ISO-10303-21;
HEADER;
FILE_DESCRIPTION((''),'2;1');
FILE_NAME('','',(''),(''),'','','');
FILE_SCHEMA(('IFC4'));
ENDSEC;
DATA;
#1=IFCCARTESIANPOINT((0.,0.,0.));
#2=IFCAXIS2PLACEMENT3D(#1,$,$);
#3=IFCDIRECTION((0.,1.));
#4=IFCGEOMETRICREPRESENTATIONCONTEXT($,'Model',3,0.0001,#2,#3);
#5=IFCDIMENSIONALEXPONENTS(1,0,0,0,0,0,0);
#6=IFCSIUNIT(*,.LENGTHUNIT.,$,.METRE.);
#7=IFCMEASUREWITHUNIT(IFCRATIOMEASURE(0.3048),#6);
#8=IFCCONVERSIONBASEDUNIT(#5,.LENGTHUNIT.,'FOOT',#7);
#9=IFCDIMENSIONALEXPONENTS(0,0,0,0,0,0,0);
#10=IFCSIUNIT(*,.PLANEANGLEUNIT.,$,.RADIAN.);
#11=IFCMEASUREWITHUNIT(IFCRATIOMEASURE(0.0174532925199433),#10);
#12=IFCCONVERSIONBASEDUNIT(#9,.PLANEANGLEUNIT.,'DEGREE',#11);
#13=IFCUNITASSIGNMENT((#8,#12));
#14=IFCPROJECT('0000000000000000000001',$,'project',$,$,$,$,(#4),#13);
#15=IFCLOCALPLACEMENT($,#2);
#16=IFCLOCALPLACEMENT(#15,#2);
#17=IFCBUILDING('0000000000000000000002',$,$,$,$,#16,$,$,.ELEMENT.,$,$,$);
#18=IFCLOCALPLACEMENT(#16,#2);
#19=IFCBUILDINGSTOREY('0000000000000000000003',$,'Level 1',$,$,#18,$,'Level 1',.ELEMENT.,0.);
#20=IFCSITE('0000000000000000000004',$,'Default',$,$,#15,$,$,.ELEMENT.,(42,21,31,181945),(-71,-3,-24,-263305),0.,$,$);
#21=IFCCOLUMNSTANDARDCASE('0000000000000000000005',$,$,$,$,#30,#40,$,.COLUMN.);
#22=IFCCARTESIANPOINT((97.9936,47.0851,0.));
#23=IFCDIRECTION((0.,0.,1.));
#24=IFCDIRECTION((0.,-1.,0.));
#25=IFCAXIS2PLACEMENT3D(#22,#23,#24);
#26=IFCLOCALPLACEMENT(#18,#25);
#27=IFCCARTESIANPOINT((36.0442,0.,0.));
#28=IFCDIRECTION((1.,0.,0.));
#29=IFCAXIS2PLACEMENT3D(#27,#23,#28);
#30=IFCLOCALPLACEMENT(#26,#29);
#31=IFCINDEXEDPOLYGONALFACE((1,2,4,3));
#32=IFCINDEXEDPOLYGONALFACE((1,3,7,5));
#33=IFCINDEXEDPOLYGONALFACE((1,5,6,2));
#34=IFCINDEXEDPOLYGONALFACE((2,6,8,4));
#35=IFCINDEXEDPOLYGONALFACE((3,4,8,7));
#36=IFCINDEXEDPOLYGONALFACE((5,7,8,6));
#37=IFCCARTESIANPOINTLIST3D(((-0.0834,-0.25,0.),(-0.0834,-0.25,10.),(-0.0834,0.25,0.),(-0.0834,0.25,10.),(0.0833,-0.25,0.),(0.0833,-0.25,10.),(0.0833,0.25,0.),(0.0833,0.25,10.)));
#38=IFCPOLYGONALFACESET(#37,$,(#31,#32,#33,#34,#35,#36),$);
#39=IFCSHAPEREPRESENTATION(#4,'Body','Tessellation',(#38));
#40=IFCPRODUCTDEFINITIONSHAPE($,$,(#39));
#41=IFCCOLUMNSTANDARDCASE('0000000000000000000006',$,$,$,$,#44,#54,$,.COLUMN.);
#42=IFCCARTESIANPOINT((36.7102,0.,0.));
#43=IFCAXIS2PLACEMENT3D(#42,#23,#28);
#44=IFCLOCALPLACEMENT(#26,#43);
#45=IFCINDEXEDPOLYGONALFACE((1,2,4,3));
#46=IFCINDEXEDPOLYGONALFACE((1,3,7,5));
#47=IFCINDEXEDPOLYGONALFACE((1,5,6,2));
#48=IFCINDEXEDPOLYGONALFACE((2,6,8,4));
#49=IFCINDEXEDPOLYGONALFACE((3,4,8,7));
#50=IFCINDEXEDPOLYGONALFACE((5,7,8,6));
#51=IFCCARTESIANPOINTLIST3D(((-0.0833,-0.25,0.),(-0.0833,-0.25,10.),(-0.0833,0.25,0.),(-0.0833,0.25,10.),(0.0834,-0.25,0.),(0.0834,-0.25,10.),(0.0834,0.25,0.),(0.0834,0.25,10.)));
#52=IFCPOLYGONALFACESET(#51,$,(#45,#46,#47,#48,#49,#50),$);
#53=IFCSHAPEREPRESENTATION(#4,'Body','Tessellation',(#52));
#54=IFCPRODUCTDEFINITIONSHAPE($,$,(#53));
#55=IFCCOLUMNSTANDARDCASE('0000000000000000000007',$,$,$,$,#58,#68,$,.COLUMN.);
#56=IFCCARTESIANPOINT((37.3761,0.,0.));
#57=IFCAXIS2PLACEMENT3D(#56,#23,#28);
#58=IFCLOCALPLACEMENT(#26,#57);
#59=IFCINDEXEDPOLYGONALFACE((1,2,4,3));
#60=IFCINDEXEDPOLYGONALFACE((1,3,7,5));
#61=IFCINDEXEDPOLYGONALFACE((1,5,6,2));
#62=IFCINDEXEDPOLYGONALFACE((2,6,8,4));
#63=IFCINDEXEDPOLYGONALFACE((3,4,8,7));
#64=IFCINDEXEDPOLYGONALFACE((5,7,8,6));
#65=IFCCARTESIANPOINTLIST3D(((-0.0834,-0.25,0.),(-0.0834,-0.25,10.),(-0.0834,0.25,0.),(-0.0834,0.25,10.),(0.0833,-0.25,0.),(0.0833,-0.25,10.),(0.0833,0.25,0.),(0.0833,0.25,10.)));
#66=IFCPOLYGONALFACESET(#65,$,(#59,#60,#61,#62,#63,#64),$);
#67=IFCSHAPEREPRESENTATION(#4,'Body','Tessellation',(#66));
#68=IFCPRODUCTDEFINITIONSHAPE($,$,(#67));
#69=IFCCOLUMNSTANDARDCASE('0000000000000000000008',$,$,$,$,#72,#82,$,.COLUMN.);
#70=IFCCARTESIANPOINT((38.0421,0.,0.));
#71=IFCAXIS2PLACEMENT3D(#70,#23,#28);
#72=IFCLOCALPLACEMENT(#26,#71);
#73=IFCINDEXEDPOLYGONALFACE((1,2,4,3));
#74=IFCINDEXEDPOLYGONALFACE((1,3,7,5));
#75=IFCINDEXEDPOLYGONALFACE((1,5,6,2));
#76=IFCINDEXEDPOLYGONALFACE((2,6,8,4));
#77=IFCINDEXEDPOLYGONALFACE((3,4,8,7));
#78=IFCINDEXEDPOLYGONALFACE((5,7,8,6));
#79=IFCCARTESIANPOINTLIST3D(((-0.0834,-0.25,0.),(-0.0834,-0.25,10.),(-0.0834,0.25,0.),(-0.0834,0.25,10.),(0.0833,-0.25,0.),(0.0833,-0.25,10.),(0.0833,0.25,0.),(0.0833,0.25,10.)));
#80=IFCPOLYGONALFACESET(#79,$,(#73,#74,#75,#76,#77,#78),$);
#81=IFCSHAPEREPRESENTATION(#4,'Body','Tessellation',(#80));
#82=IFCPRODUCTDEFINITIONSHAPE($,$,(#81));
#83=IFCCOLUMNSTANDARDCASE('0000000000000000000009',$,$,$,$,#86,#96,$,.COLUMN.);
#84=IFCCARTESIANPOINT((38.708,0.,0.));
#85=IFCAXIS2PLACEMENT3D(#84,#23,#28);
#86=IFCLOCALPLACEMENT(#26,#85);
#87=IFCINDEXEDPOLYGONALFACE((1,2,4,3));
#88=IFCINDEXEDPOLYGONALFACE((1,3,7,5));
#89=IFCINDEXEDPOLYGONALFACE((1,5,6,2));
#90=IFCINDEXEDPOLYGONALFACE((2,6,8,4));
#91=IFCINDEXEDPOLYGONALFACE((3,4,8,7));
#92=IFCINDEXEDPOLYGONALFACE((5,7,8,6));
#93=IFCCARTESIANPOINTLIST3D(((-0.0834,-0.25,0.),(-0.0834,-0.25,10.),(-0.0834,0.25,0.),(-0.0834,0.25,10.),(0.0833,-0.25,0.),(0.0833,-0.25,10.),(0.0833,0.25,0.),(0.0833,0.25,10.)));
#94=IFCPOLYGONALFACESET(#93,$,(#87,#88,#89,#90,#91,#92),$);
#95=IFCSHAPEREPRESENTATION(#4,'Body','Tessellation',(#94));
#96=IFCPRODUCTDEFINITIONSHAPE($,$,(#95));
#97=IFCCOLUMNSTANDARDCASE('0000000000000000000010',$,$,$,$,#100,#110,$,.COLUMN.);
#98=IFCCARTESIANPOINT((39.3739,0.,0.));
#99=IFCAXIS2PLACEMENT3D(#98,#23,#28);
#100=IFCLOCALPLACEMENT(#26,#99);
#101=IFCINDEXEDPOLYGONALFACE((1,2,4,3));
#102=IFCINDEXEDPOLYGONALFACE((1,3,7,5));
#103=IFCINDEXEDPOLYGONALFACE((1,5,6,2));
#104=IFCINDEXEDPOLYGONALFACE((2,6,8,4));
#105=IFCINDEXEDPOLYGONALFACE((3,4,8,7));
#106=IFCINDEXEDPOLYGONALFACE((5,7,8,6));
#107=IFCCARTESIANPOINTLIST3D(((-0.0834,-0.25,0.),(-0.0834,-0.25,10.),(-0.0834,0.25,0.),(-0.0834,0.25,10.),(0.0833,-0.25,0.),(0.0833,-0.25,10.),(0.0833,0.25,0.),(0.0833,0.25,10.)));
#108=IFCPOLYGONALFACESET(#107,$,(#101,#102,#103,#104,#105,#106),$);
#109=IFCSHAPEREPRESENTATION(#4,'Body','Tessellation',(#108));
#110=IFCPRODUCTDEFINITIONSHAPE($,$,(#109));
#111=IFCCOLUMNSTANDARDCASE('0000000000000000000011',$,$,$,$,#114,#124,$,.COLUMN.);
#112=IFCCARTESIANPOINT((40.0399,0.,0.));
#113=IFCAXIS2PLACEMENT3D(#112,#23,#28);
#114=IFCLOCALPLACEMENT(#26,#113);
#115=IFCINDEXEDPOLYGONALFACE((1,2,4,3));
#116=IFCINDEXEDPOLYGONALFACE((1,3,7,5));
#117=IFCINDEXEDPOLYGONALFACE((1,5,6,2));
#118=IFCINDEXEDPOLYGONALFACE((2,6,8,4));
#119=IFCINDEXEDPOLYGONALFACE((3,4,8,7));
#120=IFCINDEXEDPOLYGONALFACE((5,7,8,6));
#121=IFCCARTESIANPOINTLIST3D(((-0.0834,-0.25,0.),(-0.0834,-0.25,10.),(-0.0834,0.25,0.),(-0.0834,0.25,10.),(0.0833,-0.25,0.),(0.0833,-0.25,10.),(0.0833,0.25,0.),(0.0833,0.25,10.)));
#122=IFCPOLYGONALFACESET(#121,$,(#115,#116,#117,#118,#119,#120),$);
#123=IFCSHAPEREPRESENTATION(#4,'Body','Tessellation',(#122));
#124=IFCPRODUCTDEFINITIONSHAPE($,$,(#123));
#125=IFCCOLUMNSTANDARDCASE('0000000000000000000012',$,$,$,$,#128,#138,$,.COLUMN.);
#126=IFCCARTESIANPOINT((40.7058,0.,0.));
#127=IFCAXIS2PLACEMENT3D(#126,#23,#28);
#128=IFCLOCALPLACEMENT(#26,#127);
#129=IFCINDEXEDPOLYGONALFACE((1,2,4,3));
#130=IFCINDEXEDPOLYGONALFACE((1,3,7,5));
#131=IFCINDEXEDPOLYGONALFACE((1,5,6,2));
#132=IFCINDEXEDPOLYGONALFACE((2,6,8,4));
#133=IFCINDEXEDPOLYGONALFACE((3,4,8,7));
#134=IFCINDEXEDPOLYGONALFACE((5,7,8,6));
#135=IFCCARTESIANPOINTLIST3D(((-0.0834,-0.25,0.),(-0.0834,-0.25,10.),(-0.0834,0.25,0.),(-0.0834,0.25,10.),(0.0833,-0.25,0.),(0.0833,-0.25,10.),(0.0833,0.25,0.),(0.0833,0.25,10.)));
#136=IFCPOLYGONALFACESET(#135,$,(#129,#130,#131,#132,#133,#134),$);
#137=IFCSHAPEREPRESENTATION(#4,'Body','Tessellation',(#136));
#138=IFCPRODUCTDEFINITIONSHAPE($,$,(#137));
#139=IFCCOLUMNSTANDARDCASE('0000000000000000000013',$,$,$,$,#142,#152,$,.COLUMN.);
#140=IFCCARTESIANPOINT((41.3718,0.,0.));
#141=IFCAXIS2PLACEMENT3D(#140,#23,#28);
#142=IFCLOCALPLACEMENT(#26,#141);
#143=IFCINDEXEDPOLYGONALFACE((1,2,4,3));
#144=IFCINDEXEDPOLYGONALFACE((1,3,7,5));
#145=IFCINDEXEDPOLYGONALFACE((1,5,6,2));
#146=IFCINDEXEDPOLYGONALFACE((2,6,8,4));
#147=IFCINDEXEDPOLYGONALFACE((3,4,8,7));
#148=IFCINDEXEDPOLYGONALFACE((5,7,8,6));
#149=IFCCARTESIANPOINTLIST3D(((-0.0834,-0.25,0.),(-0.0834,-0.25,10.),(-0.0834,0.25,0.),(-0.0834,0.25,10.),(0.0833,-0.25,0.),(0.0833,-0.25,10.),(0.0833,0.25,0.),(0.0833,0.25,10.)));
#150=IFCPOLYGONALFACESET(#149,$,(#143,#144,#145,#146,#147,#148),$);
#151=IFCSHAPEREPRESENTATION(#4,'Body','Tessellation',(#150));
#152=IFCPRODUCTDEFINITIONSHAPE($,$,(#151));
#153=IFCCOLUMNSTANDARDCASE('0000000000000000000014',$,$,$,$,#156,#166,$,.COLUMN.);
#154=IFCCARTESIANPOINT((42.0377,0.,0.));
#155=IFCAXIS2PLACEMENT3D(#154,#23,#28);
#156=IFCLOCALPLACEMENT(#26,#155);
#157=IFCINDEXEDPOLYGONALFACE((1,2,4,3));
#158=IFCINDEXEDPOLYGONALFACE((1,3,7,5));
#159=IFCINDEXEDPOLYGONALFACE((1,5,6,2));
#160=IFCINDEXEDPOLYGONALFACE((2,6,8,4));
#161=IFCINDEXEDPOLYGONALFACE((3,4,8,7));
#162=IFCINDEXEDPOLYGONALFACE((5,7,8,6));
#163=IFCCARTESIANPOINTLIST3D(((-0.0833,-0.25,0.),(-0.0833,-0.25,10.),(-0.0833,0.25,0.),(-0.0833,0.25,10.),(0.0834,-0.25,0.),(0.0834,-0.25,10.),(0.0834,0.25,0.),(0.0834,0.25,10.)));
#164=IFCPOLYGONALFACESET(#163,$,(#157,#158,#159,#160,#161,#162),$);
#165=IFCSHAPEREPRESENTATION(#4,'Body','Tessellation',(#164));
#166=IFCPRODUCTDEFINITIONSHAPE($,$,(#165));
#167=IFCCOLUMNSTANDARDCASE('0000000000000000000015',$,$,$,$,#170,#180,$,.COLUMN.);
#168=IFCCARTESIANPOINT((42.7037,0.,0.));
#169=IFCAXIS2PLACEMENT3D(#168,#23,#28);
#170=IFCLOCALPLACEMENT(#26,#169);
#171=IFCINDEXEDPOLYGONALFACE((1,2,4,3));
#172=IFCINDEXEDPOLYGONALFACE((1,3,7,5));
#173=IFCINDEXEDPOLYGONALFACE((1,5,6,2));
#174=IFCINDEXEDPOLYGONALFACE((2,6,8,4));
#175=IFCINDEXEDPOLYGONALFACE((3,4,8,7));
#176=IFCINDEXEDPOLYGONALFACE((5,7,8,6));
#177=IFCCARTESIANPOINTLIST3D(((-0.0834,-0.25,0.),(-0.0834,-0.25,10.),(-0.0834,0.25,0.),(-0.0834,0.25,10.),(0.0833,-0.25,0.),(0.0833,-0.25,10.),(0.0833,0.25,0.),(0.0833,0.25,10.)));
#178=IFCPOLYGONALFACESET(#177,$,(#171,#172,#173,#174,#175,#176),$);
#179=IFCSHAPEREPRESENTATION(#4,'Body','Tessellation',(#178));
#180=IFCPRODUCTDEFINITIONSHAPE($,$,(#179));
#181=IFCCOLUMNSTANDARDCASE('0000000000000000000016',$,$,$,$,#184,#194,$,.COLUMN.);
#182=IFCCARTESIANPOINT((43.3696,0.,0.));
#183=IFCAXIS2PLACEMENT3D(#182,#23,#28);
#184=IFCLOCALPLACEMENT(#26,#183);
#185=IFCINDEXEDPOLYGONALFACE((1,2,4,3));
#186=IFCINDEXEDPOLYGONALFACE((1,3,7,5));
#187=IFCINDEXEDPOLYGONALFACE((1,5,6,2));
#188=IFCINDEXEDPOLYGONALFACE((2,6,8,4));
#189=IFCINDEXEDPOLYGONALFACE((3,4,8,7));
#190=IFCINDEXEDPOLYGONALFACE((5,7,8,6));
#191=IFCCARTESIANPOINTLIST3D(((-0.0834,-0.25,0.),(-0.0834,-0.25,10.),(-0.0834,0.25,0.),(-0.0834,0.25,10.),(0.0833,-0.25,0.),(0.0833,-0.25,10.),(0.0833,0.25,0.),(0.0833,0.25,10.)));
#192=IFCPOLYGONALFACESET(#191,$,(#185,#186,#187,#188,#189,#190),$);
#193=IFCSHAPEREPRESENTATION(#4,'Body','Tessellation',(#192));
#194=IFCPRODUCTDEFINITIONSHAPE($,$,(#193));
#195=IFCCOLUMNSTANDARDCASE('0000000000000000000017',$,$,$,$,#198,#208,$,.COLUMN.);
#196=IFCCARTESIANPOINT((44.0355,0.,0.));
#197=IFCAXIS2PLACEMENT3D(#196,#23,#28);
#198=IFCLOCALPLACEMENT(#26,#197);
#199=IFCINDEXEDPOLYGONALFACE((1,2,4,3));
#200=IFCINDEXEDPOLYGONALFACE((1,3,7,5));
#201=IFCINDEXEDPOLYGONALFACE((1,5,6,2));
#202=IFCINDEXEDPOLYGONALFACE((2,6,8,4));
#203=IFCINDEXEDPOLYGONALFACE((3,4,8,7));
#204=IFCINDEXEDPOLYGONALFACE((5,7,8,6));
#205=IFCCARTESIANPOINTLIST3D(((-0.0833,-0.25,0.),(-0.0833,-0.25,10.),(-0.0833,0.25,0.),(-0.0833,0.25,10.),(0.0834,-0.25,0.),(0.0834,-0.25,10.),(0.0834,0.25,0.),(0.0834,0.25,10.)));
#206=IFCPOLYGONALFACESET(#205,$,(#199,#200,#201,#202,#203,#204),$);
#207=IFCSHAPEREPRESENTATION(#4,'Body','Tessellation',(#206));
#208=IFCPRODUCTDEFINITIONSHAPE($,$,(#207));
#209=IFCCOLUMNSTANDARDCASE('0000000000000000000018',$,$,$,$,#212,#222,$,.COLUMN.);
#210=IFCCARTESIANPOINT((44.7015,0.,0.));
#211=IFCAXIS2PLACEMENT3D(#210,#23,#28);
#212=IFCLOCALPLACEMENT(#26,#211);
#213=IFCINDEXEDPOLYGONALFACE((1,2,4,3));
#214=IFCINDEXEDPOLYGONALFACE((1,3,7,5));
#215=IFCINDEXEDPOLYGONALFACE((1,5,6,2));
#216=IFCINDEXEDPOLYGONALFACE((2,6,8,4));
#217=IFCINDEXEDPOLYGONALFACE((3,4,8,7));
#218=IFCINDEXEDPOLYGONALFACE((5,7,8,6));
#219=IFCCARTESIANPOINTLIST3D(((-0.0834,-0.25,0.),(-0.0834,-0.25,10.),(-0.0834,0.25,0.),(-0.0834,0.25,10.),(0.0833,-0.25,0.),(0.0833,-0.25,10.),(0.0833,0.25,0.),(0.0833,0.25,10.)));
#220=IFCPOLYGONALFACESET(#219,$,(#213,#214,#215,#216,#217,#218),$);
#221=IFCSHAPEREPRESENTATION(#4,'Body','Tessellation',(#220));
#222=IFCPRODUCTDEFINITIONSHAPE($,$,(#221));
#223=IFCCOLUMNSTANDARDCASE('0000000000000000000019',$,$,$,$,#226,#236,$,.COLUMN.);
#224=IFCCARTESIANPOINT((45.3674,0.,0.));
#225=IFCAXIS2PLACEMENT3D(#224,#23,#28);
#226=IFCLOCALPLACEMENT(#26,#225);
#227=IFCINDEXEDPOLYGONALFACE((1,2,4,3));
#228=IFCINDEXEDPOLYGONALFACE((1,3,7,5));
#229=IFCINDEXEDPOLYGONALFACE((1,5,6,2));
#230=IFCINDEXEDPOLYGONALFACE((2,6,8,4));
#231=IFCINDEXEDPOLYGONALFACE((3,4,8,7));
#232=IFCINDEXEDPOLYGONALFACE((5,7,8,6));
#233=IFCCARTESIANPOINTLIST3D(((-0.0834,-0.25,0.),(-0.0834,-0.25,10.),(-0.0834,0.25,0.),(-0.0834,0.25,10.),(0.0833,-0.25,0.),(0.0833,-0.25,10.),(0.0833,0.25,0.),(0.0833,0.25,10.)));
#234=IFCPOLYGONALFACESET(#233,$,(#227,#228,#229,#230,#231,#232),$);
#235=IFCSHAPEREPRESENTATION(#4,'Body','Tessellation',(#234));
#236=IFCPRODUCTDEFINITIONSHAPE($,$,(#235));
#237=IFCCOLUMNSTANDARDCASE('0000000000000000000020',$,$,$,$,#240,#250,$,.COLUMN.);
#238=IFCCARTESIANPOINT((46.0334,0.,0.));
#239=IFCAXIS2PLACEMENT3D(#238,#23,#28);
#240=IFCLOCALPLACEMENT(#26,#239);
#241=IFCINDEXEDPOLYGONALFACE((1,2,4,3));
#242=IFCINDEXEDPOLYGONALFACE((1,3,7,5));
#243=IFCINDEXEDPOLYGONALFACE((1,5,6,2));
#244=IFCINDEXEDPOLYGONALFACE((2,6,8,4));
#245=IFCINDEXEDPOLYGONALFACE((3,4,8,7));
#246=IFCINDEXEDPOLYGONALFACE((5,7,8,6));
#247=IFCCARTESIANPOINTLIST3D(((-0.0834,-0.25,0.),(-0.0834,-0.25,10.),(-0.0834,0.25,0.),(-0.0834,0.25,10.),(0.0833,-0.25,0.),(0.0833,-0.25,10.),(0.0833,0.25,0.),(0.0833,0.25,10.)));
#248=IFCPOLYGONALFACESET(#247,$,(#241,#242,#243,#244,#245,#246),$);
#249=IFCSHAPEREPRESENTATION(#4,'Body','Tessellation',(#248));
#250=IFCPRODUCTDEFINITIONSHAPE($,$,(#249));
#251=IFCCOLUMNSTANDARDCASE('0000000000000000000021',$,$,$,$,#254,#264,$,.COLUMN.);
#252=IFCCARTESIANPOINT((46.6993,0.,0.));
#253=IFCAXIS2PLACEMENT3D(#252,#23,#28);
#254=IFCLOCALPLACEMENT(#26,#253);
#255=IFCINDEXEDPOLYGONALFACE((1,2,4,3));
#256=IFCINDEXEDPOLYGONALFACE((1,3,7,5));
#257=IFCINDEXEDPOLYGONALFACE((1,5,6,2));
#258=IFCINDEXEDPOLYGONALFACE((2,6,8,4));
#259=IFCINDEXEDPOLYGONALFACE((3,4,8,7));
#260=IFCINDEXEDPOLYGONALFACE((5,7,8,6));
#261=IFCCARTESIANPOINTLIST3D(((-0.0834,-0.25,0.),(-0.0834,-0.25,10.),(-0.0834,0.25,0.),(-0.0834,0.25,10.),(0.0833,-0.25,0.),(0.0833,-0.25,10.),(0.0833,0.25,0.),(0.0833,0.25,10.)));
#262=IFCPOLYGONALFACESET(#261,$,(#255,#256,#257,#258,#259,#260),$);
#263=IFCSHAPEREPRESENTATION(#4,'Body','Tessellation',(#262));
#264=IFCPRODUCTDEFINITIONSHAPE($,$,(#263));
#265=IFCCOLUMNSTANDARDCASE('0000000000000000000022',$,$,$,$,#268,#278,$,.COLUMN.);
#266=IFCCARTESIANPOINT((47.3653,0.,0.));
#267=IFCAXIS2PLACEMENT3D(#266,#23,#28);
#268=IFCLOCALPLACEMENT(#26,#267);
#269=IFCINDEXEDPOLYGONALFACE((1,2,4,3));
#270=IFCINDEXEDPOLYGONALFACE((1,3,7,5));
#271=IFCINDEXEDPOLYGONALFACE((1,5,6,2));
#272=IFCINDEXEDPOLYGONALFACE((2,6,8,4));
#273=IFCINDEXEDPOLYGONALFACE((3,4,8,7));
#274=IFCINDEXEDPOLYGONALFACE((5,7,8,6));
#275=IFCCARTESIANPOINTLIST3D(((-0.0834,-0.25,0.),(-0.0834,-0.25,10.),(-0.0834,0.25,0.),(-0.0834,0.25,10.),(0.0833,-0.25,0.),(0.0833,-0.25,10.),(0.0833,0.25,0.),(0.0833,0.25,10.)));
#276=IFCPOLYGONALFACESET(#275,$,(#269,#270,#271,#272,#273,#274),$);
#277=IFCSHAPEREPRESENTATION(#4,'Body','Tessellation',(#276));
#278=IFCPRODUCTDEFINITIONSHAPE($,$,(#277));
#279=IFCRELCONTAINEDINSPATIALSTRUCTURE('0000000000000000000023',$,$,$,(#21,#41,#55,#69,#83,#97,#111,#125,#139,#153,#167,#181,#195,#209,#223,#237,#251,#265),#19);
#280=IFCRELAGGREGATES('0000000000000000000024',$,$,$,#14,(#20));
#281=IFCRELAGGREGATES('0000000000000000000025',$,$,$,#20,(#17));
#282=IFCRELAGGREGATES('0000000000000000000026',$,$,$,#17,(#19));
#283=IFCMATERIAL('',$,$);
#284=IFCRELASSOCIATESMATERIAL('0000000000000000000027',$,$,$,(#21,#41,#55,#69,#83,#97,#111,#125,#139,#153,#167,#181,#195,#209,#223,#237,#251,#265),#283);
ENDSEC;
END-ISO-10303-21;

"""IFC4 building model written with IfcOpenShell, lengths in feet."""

from ifc_helpers import new_model, entity, si_unit, converted_unit, direction, frame, origin, place, context, project, spatial, rectangle, extrude, material, element, save


model = new_model("IFC4")

# Units and contexts
model_context = context("Model", 3, precision=0.0001, world=origin(), true_north=direction((0.0, 1.0)))
ifc_project = project(units=[converted_unit("LENGTHUNIT", "FOOT", entity("IfcRatioMeasure", 0.3048), si_unit("LENGTHUNIT", "METRE"), dimensions=[1, 0, 0, 0, 0, 0, 0]), converted_unit("PLANEANGLEUNIT", "DEGREE", entity("IfcRatioMeasure", 0.0174532925199433), si_unit("PLANEANGLEUNIT", "RADIAN"), dimensions=[0, 0, 0, 0, 0, 0, 0])], contexts=[model_context])

# Site, building, storey
site_placement = place(None, origin())
site = spatial("IfcSite", under=ifc_project, at=site_placement, Name="Default", CompositionType="ELEMENT", RefLatitude=(42, 21, 31, 181945), RefLongitude=(-71, -3, -24, -263305), RefElevation=0.0)
building_placement = place(site_placement, origin())
building = spatial("IfcBuilding", under=site, at=building_placement, CompositionType="ELEMENT")
storey_placement = place(building_placement, origin())
storey = spatial("IfcBuildingStorey", under=building, at=storey_placement, Name="Level 1", LongName="Level 1", CompositionType="ELEMENT", Elevation=0.0)

# Columns
ifc_material_1 = material(Name="")
placement = place(storey_placement, frame((97.9936, 47.0851, 0.0), z_axis=(0.0, 0.0, 1.0), x_axis=(0.0, -1.0, 0.0)))
for number, where, z_axis, x_axis in (
    (1, (36.0442, 0.0, 0.0), (0.0, 0.0, 1.0), (1.0, 0.0, 0.0)),
    (2, (36.7102, 0.0, 0.0), (0.0, 0.0, 1.0), (1.0, 0.0, 0.0)),
    (3, (37.3761, 0.0, 0.0), (0.0, 0.0, 1.0), (1.0, 0.0, 0.0)),
    (4, (38.0421, 0.0, 0.0), (0.0, 0.0, 1.0), (1.0, 0.0, 0.0)),
    (5, (38.708, 0.0, 0.0), (0.0, 0.0, 1.0), (1.0, 0.0, 0.0)),
    (6, (39.3739, 0.0, 0.0), (0.0, 0.0, 1.0), (1.0, 0.0, 0.0)),
    (7, (40.0399, 0.0, 0.0), (0.0, 0.0, 1.0), (1.0, 0.0, 0.0)),
    (8, (40.7058, 0.0, 0.0), (0.0, 0.0, 1.0), (1.0, 0.0, 0.0)),
    (9, (41.3718, 0.0, 0.0), (0.0, 0.0, 1.0), (1.0, 0.0, 0.0)),
    (10, (42.0377, 0.0, 0.0), (0.0, 0.0, 1.0), (1.0, 0.0, 0.0)),
    (11, (42.7037, 0.0, 0.0), (0.0, 0.0, 1.0), (1.0, 0.0, 0.0)),
    (12, (43.3696, 0.0, 0.0), (0.0, 0.0, 1.0), (1.0, 0.0, 0.0)),
    (13, (44.0355, 0.0, 0.0), (0.0, 0.0, 1.0), (1.0, 0.0, 0.0)),
    (14, (44.7015, 0.0, 0.0), (0.0, 0.0, 1.0), (1.0, 0.0, 0.0)),
    (15, (45.3674, 0.0, 0.0), (0.0, 0.0, 1.0), (1.0, 0.0, 0.0)),
    (16, (46.0334, 0.0, 0.0), (0.0, 0.0, 1.0), (1.0, 0.0, 0.0)),
    (17, (46.6993, 0.0, 0.0), (0.0, 0.0, 1.0), (1.0, 0.0, 0.0)),
    (18, (47.3653, 0.0, 0.0), (0.0, 0.0, 1.0), (1.0, 0.0, 0.0)),
):
    element("IfcColumnStandardCase", number, at=place(placement, frame(where, z_axis=z_axis, x_axis=x_axis)), inside=storey, material=ifc_material_1, PredefinedType="COLUMN", context=model_context, shape_type="SweptSolid", body=[
        extrude(rectangle(XDim=0.1667, YDim=0.5), origin(), (0.0, 0.0, 1.0), 10.0),
    ])

save(model, "model.ifc")
